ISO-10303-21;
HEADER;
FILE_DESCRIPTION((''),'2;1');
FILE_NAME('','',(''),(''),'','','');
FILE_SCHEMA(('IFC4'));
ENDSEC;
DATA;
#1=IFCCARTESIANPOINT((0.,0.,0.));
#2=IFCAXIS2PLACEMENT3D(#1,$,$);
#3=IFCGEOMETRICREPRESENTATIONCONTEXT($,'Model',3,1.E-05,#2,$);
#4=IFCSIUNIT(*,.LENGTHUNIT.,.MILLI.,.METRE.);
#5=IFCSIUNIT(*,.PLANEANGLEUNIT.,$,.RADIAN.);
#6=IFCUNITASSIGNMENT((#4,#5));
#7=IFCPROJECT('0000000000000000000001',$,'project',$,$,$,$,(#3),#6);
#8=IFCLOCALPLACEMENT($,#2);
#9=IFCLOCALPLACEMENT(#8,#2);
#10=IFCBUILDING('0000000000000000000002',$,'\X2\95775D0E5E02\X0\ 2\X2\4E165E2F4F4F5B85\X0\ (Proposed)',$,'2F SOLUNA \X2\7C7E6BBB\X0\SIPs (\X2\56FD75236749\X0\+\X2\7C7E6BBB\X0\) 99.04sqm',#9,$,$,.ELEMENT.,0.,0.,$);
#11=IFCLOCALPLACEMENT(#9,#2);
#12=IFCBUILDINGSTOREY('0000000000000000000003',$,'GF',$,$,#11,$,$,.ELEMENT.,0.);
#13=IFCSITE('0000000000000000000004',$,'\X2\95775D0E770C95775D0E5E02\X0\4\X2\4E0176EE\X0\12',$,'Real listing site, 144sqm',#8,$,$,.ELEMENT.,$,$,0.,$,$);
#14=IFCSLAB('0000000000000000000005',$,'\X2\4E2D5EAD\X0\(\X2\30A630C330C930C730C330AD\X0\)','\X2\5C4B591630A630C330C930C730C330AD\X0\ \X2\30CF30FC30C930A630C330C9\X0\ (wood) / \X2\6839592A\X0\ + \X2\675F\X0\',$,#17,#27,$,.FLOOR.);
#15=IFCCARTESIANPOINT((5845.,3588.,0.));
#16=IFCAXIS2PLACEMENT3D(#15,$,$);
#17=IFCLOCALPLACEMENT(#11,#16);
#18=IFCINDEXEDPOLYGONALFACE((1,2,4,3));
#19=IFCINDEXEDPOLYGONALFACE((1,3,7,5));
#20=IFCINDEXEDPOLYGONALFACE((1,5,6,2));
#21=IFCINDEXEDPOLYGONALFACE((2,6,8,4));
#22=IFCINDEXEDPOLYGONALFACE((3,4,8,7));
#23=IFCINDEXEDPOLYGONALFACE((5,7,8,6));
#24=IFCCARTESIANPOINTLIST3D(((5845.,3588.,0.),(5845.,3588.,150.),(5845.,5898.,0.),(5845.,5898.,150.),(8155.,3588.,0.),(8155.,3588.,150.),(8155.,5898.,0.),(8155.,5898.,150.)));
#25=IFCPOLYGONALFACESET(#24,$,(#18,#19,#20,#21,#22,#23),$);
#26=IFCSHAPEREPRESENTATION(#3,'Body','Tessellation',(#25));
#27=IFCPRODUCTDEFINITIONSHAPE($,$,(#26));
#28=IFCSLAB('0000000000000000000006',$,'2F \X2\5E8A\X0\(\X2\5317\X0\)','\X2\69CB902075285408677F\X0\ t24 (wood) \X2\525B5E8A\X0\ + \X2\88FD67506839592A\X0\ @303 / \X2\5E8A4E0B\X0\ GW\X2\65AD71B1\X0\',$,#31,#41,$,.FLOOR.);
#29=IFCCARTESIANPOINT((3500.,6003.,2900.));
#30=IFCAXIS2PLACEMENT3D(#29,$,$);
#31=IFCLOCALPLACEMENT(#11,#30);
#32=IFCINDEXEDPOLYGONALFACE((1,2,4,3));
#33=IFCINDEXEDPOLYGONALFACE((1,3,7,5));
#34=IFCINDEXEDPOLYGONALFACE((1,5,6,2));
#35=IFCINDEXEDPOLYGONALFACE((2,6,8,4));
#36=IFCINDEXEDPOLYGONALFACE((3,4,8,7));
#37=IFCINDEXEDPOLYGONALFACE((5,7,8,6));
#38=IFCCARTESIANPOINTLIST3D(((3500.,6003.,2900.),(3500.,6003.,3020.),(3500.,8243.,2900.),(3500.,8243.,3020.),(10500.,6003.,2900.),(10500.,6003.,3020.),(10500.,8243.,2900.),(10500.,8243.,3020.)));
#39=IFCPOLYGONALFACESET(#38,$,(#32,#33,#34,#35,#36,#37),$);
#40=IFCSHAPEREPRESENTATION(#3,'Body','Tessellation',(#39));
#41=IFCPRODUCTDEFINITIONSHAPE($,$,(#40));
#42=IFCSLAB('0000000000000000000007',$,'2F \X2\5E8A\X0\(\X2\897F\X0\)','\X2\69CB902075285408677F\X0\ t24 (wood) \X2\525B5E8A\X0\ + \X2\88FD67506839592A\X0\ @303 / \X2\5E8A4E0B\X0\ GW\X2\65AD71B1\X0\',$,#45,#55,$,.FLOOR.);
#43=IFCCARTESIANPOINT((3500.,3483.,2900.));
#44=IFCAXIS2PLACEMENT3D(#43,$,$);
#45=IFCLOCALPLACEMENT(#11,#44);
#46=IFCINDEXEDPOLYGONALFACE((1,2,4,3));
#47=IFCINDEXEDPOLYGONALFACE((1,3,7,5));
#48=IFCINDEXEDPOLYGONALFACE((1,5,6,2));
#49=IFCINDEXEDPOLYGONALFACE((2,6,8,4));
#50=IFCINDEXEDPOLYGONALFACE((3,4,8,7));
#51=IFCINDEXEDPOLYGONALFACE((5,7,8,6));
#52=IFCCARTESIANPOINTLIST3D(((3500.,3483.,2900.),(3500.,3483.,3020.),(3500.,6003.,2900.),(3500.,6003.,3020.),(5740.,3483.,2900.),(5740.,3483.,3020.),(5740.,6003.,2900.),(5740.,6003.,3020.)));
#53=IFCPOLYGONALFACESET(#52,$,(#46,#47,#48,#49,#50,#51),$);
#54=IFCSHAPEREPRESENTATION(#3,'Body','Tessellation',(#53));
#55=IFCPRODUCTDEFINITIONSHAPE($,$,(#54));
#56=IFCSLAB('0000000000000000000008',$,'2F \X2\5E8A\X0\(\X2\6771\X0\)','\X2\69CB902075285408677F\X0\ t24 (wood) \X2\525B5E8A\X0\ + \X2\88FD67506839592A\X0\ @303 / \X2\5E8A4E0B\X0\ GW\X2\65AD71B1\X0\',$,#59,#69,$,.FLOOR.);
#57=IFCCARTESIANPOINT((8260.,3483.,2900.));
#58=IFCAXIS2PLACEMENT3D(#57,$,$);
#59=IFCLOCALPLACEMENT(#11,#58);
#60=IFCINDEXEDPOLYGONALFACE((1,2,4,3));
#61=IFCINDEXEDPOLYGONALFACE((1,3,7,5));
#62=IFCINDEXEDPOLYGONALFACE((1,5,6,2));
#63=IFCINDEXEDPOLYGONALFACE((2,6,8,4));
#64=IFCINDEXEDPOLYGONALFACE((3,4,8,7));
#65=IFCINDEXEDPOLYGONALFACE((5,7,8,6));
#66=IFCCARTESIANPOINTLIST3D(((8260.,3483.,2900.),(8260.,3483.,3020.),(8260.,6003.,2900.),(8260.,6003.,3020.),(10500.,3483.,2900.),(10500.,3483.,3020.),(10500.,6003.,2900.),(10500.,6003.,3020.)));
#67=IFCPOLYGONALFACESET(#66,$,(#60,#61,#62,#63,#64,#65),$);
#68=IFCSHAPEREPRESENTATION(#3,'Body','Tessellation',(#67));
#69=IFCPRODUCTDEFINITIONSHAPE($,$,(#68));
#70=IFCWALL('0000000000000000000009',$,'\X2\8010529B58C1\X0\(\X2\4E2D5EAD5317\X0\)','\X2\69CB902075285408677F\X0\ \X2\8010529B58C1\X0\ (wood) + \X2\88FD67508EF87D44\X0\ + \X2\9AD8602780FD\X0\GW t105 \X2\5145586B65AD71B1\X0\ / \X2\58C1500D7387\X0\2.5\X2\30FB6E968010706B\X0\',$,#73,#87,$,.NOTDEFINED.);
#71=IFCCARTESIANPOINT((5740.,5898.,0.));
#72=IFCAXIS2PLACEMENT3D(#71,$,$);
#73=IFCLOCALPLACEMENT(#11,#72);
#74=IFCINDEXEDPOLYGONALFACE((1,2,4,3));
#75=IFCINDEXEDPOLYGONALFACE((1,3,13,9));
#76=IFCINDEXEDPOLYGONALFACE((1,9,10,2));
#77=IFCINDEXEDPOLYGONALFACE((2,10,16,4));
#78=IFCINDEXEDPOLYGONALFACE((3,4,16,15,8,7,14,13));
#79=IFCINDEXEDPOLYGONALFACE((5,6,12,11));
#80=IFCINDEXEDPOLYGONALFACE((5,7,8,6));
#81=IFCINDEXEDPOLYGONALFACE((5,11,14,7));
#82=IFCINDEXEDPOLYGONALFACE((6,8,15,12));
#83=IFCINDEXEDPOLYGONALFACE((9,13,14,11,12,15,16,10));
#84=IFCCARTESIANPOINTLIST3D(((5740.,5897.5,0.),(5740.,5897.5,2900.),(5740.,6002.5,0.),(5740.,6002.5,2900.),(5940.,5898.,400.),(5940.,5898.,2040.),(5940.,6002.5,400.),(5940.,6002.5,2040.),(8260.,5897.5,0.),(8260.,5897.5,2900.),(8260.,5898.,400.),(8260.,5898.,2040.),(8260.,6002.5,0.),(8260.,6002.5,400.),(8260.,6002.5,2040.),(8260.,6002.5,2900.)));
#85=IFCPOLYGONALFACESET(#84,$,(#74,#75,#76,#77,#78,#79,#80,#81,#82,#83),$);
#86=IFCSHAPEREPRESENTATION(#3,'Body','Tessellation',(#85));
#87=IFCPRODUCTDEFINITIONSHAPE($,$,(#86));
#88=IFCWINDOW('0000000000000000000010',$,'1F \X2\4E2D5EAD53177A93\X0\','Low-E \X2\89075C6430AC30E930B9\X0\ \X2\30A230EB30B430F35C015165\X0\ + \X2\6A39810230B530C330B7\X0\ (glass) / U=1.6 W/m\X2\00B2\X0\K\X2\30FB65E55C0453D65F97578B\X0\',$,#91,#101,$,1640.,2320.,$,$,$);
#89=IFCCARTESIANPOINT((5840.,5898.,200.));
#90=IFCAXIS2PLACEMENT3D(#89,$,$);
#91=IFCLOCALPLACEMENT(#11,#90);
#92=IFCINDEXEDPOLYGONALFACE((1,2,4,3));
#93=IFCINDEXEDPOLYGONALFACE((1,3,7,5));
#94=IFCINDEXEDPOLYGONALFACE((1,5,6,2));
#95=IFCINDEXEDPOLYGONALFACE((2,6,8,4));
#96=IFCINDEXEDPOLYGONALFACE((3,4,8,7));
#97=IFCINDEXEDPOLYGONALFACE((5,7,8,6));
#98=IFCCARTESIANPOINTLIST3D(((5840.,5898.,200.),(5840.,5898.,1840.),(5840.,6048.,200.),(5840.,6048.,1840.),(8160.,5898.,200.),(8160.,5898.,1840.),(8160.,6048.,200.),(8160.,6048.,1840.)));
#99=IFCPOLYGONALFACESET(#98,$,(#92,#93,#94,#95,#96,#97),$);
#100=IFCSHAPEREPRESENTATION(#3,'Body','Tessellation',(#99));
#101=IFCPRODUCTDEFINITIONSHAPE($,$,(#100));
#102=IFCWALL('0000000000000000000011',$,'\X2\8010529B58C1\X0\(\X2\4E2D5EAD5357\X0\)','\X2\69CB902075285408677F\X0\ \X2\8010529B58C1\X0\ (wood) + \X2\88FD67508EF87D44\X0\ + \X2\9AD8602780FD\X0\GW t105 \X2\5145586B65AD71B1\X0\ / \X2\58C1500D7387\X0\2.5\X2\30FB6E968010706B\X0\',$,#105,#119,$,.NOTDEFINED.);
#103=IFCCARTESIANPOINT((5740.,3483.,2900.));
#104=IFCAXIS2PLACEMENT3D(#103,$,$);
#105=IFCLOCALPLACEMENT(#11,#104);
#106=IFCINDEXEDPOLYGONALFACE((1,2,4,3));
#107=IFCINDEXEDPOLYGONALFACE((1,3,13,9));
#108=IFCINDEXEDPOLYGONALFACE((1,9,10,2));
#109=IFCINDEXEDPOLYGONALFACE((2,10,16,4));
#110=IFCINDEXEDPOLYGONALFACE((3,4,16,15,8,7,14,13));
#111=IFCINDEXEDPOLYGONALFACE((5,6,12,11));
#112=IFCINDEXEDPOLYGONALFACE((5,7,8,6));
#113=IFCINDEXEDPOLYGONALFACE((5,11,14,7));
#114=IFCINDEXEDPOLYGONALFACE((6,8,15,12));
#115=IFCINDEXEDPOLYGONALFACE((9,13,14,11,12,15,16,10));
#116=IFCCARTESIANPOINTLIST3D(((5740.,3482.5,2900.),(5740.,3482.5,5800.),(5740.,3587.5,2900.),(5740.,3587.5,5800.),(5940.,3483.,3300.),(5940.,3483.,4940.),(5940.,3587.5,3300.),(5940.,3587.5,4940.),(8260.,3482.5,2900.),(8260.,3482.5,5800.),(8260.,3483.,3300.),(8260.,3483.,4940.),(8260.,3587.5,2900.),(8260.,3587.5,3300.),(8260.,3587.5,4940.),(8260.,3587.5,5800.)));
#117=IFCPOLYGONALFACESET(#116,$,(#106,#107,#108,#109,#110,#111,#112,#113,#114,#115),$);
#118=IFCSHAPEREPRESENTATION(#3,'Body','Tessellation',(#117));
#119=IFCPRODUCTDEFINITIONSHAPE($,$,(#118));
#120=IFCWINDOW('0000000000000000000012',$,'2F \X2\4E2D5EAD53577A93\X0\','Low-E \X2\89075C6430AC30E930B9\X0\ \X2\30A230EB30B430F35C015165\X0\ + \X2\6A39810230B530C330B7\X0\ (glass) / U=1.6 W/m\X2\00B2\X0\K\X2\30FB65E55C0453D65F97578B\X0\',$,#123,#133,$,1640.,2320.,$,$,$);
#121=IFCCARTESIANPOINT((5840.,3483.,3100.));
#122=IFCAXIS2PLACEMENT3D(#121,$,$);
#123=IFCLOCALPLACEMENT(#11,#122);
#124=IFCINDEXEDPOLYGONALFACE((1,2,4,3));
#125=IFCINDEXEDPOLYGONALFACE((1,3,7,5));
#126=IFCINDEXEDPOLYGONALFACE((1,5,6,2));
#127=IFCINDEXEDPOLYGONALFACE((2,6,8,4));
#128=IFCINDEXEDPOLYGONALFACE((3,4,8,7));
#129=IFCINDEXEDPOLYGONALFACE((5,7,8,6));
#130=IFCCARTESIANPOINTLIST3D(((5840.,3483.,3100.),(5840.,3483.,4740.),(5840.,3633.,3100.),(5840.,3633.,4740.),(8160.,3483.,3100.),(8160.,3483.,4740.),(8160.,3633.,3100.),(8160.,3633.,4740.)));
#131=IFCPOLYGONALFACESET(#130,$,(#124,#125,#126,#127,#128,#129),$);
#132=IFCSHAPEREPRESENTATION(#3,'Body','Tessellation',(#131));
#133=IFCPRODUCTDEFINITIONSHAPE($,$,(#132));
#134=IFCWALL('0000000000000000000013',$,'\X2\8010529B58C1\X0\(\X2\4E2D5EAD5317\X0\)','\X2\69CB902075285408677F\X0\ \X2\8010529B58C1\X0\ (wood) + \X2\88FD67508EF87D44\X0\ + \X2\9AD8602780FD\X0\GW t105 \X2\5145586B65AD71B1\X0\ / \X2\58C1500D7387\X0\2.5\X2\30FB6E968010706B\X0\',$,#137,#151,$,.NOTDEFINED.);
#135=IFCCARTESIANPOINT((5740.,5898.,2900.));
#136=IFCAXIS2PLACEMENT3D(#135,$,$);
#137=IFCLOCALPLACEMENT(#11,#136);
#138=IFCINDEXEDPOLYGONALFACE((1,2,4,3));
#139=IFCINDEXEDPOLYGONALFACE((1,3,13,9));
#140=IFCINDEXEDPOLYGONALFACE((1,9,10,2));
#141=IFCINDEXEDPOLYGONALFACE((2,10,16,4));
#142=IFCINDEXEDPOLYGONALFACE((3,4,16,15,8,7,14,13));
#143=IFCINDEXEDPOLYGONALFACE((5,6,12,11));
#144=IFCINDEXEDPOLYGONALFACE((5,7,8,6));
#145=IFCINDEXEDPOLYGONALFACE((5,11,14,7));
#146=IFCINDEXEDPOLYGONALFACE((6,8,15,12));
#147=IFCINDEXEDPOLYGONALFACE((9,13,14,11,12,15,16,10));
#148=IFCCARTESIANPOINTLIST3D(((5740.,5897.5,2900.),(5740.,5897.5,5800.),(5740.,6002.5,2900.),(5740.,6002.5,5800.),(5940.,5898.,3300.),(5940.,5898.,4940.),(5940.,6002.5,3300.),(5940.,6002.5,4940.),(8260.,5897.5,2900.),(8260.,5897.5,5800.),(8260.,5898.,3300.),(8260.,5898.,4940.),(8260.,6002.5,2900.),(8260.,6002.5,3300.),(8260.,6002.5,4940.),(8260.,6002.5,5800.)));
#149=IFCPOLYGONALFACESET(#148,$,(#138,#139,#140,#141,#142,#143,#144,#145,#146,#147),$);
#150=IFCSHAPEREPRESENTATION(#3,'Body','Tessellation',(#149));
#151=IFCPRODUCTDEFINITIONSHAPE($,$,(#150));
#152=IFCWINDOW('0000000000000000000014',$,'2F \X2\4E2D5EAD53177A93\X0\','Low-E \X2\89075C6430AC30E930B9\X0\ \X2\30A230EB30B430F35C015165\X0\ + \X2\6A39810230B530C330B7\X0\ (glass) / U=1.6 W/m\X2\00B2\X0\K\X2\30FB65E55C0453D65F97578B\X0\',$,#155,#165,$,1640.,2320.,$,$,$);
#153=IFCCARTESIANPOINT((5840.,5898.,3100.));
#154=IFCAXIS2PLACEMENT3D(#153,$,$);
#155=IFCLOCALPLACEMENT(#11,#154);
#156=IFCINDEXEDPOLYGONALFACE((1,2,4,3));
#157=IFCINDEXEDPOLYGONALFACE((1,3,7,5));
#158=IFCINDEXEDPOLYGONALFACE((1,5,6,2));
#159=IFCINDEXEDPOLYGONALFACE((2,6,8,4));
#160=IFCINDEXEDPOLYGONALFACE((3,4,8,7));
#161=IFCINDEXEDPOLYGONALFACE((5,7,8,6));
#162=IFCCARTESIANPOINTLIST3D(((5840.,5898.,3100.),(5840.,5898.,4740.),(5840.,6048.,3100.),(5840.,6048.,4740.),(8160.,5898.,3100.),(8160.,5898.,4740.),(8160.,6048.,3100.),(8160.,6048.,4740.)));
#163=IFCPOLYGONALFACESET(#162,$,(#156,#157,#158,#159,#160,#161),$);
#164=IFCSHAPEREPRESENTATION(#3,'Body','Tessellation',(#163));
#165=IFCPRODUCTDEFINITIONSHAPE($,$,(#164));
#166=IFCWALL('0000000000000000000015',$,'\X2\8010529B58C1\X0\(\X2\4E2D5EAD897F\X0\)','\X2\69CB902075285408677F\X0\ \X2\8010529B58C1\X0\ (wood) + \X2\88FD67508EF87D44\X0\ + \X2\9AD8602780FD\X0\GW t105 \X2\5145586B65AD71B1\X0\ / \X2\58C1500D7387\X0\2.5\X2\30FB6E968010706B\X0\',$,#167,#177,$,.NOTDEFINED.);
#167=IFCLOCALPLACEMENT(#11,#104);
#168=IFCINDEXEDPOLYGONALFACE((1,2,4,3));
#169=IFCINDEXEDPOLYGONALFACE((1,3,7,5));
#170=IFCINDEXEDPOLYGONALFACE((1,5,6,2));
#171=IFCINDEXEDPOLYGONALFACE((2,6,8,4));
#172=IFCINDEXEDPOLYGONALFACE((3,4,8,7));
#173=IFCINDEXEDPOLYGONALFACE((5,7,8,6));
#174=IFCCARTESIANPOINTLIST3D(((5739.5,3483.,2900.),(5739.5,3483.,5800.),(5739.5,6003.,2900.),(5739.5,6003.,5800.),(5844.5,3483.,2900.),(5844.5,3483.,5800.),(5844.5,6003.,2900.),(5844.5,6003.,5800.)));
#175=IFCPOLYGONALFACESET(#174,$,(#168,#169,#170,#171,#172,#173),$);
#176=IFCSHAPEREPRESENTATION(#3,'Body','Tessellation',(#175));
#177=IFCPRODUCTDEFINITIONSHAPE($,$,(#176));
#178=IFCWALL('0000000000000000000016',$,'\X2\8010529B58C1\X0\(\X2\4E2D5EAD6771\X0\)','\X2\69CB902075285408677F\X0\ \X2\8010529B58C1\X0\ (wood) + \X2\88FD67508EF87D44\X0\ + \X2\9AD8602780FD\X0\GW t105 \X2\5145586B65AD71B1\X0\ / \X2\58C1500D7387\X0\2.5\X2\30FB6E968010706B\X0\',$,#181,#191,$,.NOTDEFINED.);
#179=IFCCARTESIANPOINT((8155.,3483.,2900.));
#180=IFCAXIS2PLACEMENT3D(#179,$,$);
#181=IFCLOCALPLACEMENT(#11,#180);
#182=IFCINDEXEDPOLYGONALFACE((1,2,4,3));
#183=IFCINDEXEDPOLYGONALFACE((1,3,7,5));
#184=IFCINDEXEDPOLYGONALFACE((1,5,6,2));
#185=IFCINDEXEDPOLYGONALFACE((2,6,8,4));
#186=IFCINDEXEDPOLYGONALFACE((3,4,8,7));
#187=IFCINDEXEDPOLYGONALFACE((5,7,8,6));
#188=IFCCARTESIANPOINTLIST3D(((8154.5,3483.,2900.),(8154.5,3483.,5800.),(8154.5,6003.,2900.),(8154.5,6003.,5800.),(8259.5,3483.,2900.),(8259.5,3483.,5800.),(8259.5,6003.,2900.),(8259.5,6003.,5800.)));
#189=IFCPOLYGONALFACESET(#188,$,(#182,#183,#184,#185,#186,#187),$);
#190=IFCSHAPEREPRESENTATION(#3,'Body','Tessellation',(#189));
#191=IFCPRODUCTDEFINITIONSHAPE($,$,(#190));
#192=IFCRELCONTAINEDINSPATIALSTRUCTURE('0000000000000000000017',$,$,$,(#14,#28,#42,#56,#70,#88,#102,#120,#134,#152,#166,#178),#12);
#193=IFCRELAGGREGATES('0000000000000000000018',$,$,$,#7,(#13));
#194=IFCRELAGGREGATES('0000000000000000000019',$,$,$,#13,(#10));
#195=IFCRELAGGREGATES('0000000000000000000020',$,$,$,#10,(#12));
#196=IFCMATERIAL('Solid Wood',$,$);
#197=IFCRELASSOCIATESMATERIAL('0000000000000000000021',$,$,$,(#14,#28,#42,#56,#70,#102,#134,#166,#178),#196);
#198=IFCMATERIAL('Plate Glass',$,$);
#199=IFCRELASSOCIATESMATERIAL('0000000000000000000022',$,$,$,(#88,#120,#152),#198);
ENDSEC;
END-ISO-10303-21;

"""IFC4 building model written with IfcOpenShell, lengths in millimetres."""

from ifc_helpers import new_model, si_unit, frame, frame_2d, origin, place, context, project, spatial, rectangle, extrude, material, element, fill, save


model = new_model("IFC4")

# Units and contexts
model_context = context("Model", 3, precision=1e-05, world=origin())
ifc_project = project(units=[si_unit("LENGTHUNIT", "METRE", prefix="MILLI"), si_unit("PLANEANGLEUNIT", "RADIAN")], contexts=[model_context])

# Site, building, storey
site_placement = place(None, origin())
site = spatial("IfcSite", under=ifc_project, at=site_placement, Name="長崎県長崎市4丁目12", ObjectType="Real listing site, 144sqm", CompositionType="ELEMENT", RefElevation=0.0)
building_placement = place(site_placement, origin())
building = spatial("IfcBuilding", under=site, at=building_placement, Name="長崎市 2世帯住宅 (Proposed)", ObjectType="2F SOLUNA 籾殻SIPs (国産杉+籾殻) 99.04sqm", CompositionType="ELEMENT", ElevationOfRefHeight=0.0, ElevationOfTerrain=0.0)
storey_placement = place(building_placement, origin())
storey = spatial("IfcBuildingStorey", under=building, at=storey_placement, Name="GF", CompositionType="ELEMENT", Elevation=0.0)

# Slabs
ifc_material_1 = material(Name="Solid Wood")
slab_1_placement = place(storey_placement, frame((5845.0, 3588.0, 0.0)))
element("IfcSlab", 1, at=slab_1_placement, inside=storey, material=ifc_material_1, Name="中庭(ウッドデッキ)", Description="屋外ウッドデッキ ハードウッド (wood) / 根太 + 束", PredefinedType="FLOOR", context=model_context, shape_type="SweptSolid", body=[
    extrude(rectangle(XDim=2310.0, YDim=2310.0, at=frame_2d((1155.0, 1155.0))), frame((5845.0, 3588.0, 0.0)), (0.0, 0.0, 1.0), 150.0),
])
slab_2_placement = place(storey_placement, frame((3500.0, 6003.0, 2900.0)))
element("IfcSlab", 2, at=slab_2_placement, inside=storey, material=ifc_material_1, Name="2F 床(北)", Description="構造用合板 t24 (wood) 剛床 + 製材根太 @303 / 床下 GW断熱", PredefinedType="FLOOR", context=model_context, shape_type="SweptSolid", body=[
    extrude(rectangle(XDim=7000.0, YDim=2240.0, at=frame_2d((3500.0, 1120.0))), frame((3500.0, 6003.0, 2900.0)), (0.0, 0.0, 1.0), 120.0),
])
slab_3_placement = place(storey_placement, frame((3500.0, 3483.0, 2900.0)))
element("IfcSlab", 3, at=slab_3_placement, inside=storey, material=ifc_material_1, Name="2F 床(西)", Description="構造用合板 t24 (wood) 剛床 + 製材根太 @303 / 床下 GW断熱", PredefinedType="FLOOR", context=model_context, shape_type="SweptSolid", body=[
    extrude(rectangle(XDim=2240.0, YDim=2520.0, at=frame_2d((1120.0, 1260.0))), frame((3500.0, 3483.0, 2900.0)), (0.0, 0.0, 1.0), 120.0),
])
slab_4_placement = place(storey_placement, frame((8260.0, 3483.0, 2900.0)))
element("IfcSlab", 4, at=slab_4_placement, inside=storey, material=ifc_material_1, Name="2F 床(東)", Description="構造用合板 t24 (wood) 剛床 + 製材根太 @303 / 床下 GW断熱", PredefinedType="FLOOR", context=model_context, shape_type="SweptSolid", body=[
    extrude(rectangle(XDim=2240.0, YDim=2520.0, at=frame_2d((1120.0, 1260.0))), frame((8260.0, 3483.0, 2900.0)), (0.0, 0.0, 1.0), 120.0),
])

# Wall, opening, window
wall_1_placement = place(storey_placement, frame((5740.0, 5898.0, 0.0)))
wall_1 = element("IfcWall", 5, at=wall_1_placement, inside=storey, material=ifc_material_1, Name="耐力壁(中庭北)", Description="構造用合板 耐力壁 (wood) + 製材軸組 + 高性能GW t105 充填断熱 / 壁倍率2.5・準耐火", PredefinedType="NOTDEFINED", context=model_context, shape_type="SweptSolid", body=[
    extrude(rectangle(XDim=2520.0, YDim=105.0, at=frame_2d((1260.0, 52.0))), frame((5740.0, 5898.0, 0.0)), (0.0, 0.0, 1.0), 2900.0),
])
opening_1_placement = place(storey_placement, frame((5840.0, 5898.0, 200.0)))
opening_1 = element("IfcOpeningElement", 6, at=opening_1_placement, cuts=wall_1, PredefinedType="NOTDEFINED", context=model_context, shape_type="SweptSolid", body=[
    extrude(rectangle(XDim=2320.0, YDim=150.0, at=frame_2d((1160.0, 75.0))), frame((5840.0, 5898.0, 200.0)), (0.0, 0.0, 1.0), 1640.0),
])
ifc_material_2 = material(Name="Plate Glass")
window_1_placement = place(storey_placement, frame((5840.0, 5898.0, 200.0)))
window_1 = element("IfcWindow", 7, at=window_1_placement, inside=storey, material=ifc_material_2, Name="1F 中庭北窓", Description="Low-E 複層ガラス アルゴン封入 + 樹脂サッシ (glass) / U=1.6 W/m²K・日射取得型", OverallHeight=1640.0, OverallWidth=2320.0, context=model_context, shape_type="SweptSolid", body=[
    extrude(rectangle(XDim=2320.0, YDim=150.0, at=frame_2d((1160.0, 75.0))), frame((5840.0, 5898.0, 200.0)), (0.0, 0.0, 1.0), 1640.0),
])
fill(opening_1, window_1)

# Walls, openings, windows
wall_2_placement = place(storey_placement, frame((5740.0, 3483.0, 2900.0)))
wall_2 = element("IfcWall", 8, at=wall_2_placement, inside=storey, material=ifc_material_1, Name="耐力壁(中庭南)", Description="構造用合板 耐力壁 (wood) + 製材軸組 + 高性能GW t105 充填断熱 / 壁倍率2.5・準耐火", PredefinedType="NOTDEFINED", context=model_context, shape_type="SweptSolid", body=[
    extrude(rectangle(XDim=2520.0, YDim=105.0, at=frame_2d((1260.0, 52.0))), frame((5740.0, 3483.0, 2900.0)), (0.0, 0.0, 1.0), 2900.0),
])
opening_2_placement = place(storey_placement, frame((5840.0, 3483.0, 3100.0)))
opening_2 = element("IfcOpeningElement", 9, at=opening_2_placement, cuts=wall_2, PredefinedType="NOTDEFINED", context=model_context, shape_type="SweptSolid", body=[
    extrude(rectangle(XDim=2320.0, YDim=150.0, at=frame_2d((1160.0, 75.0))), frame((5840.0, 3483.0, 3100.0)), (0.0, 0.0, 1.0), 1640.0),
])
window_2_placement = place(storey_placement, frame((5840.0, 3483.0, 3100.0)))
window_2 = element("IfcWindow", 10, at=window_2_placement, inside=storey, material=ifc_material_2, Name="2F 中庭南窓", Description="Low-E 複層ガラス アルゴン封入 + 樹脂サッシ (glass) / U=1.6 W/m²K・日射取得型", OverallHeight=1640.0, OverallWidth=2320.0, context=model_context, shape_type="SweptSolid", body=[
    extrude(rectangle(XDim=2320.0, YDim=150.0, at=frame_2d((1160.0, 75.0))), frame((5840.0, 3483.0, 3100.0)), (0.0, 0.0, 1.0), 1640.0),
])
fill(opening_2, window_2)
wall_3_placement = place(storey_placement, frame((5740.0, 5898.0, 2900.0)))
wall_3 = element("IfcWall", 11, at=wall_3_placement, inside=storey, material=ifc_material_1, Name="耐力壁(中庭北)", Description="構造用合板 耐力壁 (wood) + 製材軸組 + 高性能GW t105 充填断熱 / 壁倍率2.5・準耐火", PredefinedType="NOTDEFINED", context=model_context, shape_type="SweptSolid", body=[
    extrude(rectangle(XDim=2520.0, YDim=105.0, at=frame_2d((1260.0, 52.0))), frame((5740.0, 5898.0, 2900.0)), (0.0, 0.0, 1.0), 2900.0),
])
opening_3_placement = place(storey_placement, frame((5840.0, 5898.0, 3100.0)))
opening_3 = element("IfcOpeningElement", 12, at=opening_3_placement, cuts=wall_3, PredefinedType="NOTDEFINED", context=model_context, shape_type="SweptSolid", body=[
    extrude(rectangle(XDim=2320.0, YDim=150.0, at=frame_2d((1160.0, 75.0))), frame((5840.0, 5898.0, 3100.0)), (0.0, 0.0, 1.0), 1640.0),
])
window_3_placement = place(storey_placement, frame((5840.0, 5898.0, 3100.0)))
window_3 = element("IfcWindow", 13, at=window_3_placement, inside=storey, material=ifc_material_2, Name="2F 中庭北窓", Description="Low-E 複層ガラス アルゴン封入 + 樹脂サッシ (glass) / U=1.6 W/m²K・日射取得型", OverallHeight=1640.0, OverallWidth=2320.0, context=model_context, shape_type="SweptSolid", body=[
    extrude(rectangle(XDim=2320.0, YDim=150.0, at=frame_2d((1160.0, 75.0))), frame((5840.0, 5898.0, 3100.0)), (0.0, 0.0, 1.0), 1640.0),
])
fill(opening_3, window_3)

# Walls
wall_4_placement = place(storey_placement, frame((5740.0, 3483.0, 2900.0)))
element("IfcWall", 14, at=wall_4_placement, inside=storey, material=ifc_material_1, Name="耐力壁(中庭西)", Description="構造用合板 耐力壁 (wood) + 製材軸組 + 高性能GW t105 充填断熱 / 壁倍率2.5・準耐火", PredefinedType="NOTDEFINED", context=model_context, shape_type="SweptSolid", body=[
    extrude(rectangle(XDim=105.0, YDim=2520.0, at=frame_2d((52.0, 1260.0))), frame((5740.0, 3483.0, 2900.0)), (0.0, 0.0, 1.0), 2900.0),
])
wall_5_placement = place(storey_placement, frame((8155.0, 3483.0, 2900.0)))
element("IfcWall", 15, at=wall_5_placement, inside=storey, material=ifc_material_1, Name="耐力壁(中庭東)", Description="構造用合板 耐力壁 (wood) + 製材軸組 + 高性能GW t105 充填断熱 / 壁倍率2.5・準耐火", PredefinedType="NOTDEFINED", context=model_context, shape_type="SweptSolid", body=[
    extrude(rectangle(XDim=105.0, YDim=2520.0, at=frame_2d((52.0, 1260.0))), frame((8155.0, 3483.0, 2900.0)), (0.0, 0.0, 1.0), 2900.0),
])

save(model, "model.ifc")
